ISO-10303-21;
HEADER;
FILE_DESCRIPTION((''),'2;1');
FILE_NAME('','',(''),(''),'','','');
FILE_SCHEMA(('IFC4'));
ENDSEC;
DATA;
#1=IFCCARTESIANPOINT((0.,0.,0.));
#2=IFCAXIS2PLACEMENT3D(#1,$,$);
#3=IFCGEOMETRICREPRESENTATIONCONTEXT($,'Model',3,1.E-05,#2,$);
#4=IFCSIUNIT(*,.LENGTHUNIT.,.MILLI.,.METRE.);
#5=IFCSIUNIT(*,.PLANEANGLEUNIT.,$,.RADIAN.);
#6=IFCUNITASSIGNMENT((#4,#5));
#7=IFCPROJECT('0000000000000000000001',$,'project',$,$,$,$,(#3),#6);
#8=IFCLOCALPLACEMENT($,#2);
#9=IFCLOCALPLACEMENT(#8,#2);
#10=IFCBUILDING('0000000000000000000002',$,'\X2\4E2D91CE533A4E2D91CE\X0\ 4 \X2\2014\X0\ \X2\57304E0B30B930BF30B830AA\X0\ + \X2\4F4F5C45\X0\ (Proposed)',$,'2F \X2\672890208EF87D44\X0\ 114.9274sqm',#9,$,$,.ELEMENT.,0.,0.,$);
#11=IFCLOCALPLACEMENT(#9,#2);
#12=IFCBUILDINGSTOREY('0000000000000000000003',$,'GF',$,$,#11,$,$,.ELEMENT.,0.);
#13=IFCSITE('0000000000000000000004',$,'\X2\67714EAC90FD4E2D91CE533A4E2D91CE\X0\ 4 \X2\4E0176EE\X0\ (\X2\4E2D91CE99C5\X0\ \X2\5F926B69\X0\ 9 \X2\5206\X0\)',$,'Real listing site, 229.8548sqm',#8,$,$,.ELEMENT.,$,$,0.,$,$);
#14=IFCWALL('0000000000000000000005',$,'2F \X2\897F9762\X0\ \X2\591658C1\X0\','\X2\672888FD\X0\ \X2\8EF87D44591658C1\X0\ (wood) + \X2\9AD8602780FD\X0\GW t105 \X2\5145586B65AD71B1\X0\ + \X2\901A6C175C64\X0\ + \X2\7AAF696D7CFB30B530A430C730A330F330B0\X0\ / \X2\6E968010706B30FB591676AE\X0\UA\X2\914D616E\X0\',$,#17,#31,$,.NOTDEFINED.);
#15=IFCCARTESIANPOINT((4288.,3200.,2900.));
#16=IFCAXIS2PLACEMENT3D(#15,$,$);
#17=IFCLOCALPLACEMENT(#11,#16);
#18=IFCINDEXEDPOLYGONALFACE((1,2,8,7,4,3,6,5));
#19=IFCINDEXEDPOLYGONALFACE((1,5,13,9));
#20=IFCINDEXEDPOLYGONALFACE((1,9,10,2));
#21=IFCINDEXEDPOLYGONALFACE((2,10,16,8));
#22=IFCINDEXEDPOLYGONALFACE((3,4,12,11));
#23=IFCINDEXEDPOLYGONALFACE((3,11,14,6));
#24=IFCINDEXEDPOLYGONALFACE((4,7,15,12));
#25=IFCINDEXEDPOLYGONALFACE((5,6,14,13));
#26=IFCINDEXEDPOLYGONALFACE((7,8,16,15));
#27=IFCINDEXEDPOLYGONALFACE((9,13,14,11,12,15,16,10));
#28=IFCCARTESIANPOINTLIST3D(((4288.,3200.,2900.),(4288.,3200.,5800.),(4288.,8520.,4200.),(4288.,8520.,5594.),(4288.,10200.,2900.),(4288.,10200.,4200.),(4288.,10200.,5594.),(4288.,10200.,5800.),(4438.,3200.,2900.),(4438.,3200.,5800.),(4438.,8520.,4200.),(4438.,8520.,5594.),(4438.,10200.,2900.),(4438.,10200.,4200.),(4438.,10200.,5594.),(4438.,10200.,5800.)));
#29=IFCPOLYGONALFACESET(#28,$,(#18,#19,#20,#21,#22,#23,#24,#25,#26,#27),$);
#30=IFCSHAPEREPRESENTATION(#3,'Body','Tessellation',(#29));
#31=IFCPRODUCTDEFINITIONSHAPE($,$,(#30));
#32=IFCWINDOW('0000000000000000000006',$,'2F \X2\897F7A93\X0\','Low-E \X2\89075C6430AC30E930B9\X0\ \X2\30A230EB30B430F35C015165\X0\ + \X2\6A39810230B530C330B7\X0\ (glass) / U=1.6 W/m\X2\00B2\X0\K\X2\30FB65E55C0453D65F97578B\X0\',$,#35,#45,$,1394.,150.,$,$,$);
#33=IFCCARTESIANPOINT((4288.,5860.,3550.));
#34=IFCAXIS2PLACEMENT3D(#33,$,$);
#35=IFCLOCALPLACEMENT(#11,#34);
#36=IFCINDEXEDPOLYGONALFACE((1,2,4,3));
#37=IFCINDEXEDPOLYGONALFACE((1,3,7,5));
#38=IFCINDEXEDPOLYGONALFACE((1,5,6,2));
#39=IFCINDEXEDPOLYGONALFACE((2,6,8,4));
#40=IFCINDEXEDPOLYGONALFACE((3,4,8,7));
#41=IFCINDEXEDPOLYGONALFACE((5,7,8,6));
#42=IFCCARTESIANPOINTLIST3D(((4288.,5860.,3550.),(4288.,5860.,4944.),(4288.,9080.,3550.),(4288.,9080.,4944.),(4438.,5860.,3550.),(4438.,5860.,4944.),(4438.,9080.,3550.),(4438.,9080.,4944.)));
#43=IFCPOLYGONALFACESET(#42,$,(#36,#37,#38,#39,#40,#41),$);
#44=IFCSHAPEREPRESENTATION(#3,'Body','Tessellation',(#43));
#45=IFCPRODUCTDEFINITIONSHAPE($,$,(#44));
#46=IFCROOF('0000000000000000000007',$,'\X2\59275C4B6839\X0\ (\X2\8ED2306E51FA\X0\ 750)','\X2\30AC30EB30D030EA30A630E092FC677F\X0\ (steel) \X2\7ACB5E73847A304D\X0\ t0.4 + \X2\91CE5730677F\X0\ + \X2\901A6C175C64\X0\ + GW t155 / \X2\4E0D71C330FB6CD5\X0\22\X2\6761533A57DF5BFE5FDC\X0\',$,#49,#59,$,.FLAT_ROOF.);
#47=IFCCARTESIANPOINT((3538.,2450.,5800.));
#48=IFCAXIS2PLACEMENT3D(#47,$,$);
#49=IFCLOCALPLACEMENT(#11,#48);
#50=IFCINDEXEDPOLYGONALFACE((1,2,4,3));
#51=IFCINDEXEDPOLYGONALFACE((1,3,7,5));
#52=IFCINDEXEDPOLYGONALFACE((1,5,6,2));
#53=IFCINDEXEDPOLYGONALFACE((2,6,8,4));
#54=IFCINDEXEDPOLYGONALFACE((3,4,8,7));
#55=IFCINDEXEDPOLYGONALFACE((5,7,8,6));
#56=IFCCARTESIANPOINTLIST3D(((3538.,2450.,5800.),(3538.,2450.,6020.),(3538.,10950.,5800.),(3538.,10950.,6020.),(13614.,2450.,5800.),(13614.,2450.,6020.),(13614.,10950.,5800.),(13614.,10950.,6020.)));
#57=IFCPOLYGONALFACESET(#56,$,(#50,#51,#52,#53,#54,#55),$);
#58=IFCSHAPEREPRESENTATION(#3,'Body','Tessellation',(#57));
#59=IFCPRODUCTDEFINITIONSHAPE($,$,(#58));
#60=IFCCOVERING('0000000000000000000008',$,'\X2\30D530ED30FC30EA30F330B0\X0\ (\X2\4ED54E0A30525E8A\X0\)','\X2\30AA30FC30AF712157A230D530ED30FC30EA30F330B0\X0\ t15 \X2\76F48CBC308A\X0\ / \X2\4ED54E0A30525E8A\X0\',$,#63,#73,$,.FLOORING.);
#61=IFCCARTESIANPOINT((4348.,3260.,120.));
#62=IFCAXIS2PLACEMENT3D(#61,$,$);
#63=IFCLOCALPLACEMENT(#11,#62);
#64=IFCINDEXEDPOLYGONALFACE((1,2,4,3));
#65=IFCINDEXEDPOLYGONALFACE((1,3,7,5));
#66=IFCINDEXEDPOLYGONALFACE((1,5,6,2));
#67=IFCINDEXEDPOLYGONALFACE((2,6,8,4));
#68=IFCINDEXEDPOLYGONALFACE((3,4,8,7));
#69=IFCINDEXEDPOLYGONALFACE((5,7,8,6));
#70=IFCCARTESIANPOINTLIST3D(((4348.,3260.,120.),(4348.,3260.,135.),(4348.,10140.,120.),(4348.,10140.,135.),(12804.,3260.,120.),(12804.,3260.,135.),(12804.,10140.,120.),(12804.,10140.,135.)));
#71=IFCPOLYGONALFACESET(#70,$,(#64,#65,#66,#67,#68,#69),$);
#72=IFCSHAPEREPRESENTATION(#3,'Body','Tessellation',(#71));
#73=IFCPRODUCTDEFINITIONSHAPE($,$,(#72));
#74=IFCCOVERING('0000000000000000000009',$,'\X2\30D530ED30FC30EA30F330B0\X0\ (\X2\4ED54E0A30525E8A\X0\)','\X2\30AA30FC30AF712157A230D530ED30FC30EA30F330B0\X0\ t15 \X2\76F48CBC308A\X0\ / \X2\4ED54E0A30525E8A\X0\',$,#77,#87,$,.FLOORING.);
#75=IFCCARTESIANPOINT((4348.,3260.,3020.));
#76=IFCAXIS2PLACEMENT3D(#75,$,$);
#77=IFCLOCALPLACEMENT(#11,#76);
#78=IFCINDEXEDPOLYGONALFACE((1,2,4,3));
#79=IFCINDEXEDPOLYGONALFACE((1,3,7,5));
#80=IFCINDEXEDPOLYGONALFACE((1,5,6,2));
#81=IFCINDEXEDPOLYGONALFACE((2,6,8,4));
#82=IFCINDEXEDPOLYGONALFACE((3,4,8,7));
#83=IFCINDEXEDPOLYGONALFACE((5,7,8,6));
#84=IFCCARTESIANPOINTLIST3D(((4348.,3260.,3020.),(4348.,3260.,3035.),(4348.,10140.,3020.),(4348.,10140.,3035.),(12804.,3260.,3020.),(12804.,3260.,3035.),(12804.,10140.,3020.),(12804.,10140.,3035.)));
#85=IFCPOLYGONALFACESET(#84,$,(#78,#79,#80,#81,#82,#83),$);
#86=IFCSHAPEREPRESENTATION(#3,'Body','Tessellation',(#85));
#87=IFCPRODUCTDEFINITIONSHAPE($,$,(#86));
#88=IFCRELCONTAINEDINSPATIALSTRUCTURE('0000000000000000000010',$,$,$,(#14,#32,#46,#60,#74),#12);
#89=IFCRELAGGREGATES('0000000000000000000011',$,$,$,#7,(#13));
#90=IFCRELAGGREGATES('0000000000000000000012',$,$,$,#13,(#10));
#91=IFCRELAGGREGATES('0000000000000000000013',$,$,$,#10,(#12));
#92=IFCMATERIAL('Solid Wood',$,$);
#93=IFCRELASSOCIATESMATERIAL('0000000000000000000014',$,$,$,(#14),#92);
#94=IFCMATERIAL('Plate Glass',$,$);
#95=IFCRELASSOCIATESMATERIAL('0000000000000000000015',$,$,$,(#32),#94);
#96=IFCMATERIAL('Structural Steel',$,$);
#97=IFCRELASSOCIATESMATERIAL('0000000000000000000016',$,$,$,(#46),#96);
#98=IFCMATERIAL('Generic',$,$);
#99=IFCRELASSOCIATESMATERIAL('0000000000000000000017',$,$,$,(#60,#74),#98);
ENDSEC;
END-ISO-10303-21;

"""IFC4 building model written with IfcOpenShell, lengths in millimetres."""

from ifc_helpers import new_model, si_unit, frame, frame_2d, origin, place, context, project, spatial, rectangle, extrude, material, element, fill, save


model = new_model("IFC4")

# Units and contexts
model_context = context("Model", 3, precision=1e-05, world=origin())
ifc_project = project(units=[si_unit("LENGTHUNIT", "METRE", prefix="MILLI"), si_unit("PLANEANGLEUNIT", "RADIAN")], contexts=[model_context])

# Site, building, storey
site_placement = place(None, origin())
site = spatial("IfcSite", under=ifc_project, at=site_placement, Name="東京都中野区中野 4 丁目 (中野駅 徒歩 9 分)", ObjectType="Real listing site, 229.8548sqm", CompositionType="ELEMENT", RefElevation=0.0)
building_placement = place(site_placement, origin())
building = spatial("IfcBuilding", under=site, at=building_placement, Name="中野区中野 4 — 地下スタジオ + 住居 (Proposed)", ObjectType="2F 木造軸組 114.9274sqm", CompositionType="ELEMENT", ElevationOfRefHeight=0.0, ElevationOfTerrain=0.0)
storey_placement = place(building_placement, origin())
storey = spatial("IfcBuildingStorey", under=building, at=storey_placement, Name="GF", CompositionType="ELEMENT", Elevation=0.0)

# Shared definitions
ifc_material_1 = material(Name="Solid Wood")

# Shared definitions
ifc_material_2 = material(Name="Plate Glass")

# Wall, opening, window
wall_1_placement = place(storey_placement, frame((4288.0, 3200.0, 2900.0)))
wall_1 = element("IfcWall", 1, at=wall_1_placement, inside=storey, material=ifc_material_1, Name="2F 西面 外壁", Description="木製 軸組外壁 (wood) + 高性能GW t105 充填断熱 + 通気層 + 窯業系サイディング / 準耐火・外皮UA配慮", PredefinedType="NOTDEFINED", context=model_context, shape_type="SweptSolid", body=[
    extrude(rectangle(XDim=150.0, YDim=7000.0, at=frame_2d((75.0, 3500.0))), frame((4288.0, 3200.0, 2900.0)), (0.0, 0.0, 1.0), 2900.0),
])
opening_1_placement = place(storey_placement, frame((4288.0, 5860.0, 3550.0)))
opening_1 = element("IfcOpeningElement", 2, at=opening_1_placement, cuts=wall_1, PredefinedType="NOTDEFINED", context=model_context, shape_type="SweptSolid", body=[
    extrude(rectangle(XDim=150.0, YDim=3220.0, at=frame_2d((75.0, 1610.0))), frame((4288.0, 5860.0, 3550.0)), (0.0, 0.0, 1.0), 1394.0),
])
window_1_placement = place(storey_placement, frame((4288.0, 5860.0, 3550.0)))
window_1 = element("IfcWindow", 3, at=window_1_placement, inside=storey, material=ifc_material_2, Name="2F 西窓", Description="Low-E 複層ガラス アルゴン封入 + 樹脂サッシ (glass) / U=1.6 W/m²K・日射取得型", OverallHeight=1394.0, OverallWidth=150.0, context=model_context, shape_type="SweptSolid", body=[
    extrude(rectangle(XDim=150.0, YDim=3220.0, at=frame_2d((75.0, 1610.0))), frame((4288.0, 5860.0, 3550.0)), (0.0, 0.0, 1.0), 1394.0),
])
fill(opening_1, window_1)

# Roof
ifc_material_3 = material(Name="Structural Steel")
roof_placement = place(storey_placement, frame((3538.0, 2450.0, 5800.0)))
element("IfcRoof", 4, at=roof_placement, inside=storey, material=ifc_material_3, Name="大屋根 (軒の出 750)", Description="ガルバリウム鋼板 (steel) 立平葺き t0.4 + 野地板 + 通気層 + GW t155 / 不燃・法22条区域対応", PredefinedType="FLAT_ROOF", context=model_context, shape_type="SweptSolid", body=[
    extrude(rectangle(XDim=10076.0, YDim=8500.0, at=frame_2d((5038.0, 4250.0))), frame((3538.0, 2450.0, 5800.0)), (0.0, 0.0, 1.0), 220.0),
])

# Coverings
ifc_material_4 = material(Name="Generic")
covering_1_placement = place(storey_placement, frame((4348.0, 3260.0, 120.0)))
element("IfcCovering", 5, at=covering_1_placement, inside=storey, material=ifc_material_4, Name="フローリング (仕上げ床)", Description="オーク無垢フローリング t15 直貼り / 仕上げ床", PredefinedType="FLOORING", context=model_context, shape_type="SweptSolid", body=[
    extrude(rectangle(XDim=8456.0, YDim=6880.0, at=frame_2d((4228.0, 3440.0))), frame((4348.0, 3260.0, 120.0)), (0.0, 0.0, 1.0), 15.0),
])
covering_2_placement = place(storey_placement, frame((4348.0, 3260.0, 3020.0)))
element("IfcCovering", 6, at=covering_2_placement, inside=storey, material=ifc_material_4, Name="フローリング (仕上げ床)", Description="オーク無垢フローリング t15 直貼り / 仕上げ床", PredefinedType="FLOORING", context=model_context, shape_type="SweptSolid", body=[
    extrude(rectangle(XDim=8456.0, YDim=6880.0, at=frame_2d((4228.0, 3440.0))), frame((4348.0, 3260.0, 3020.0)), (0.0, 0.0, 1.0), 15.0),
])

save(model, "model.ifc")
